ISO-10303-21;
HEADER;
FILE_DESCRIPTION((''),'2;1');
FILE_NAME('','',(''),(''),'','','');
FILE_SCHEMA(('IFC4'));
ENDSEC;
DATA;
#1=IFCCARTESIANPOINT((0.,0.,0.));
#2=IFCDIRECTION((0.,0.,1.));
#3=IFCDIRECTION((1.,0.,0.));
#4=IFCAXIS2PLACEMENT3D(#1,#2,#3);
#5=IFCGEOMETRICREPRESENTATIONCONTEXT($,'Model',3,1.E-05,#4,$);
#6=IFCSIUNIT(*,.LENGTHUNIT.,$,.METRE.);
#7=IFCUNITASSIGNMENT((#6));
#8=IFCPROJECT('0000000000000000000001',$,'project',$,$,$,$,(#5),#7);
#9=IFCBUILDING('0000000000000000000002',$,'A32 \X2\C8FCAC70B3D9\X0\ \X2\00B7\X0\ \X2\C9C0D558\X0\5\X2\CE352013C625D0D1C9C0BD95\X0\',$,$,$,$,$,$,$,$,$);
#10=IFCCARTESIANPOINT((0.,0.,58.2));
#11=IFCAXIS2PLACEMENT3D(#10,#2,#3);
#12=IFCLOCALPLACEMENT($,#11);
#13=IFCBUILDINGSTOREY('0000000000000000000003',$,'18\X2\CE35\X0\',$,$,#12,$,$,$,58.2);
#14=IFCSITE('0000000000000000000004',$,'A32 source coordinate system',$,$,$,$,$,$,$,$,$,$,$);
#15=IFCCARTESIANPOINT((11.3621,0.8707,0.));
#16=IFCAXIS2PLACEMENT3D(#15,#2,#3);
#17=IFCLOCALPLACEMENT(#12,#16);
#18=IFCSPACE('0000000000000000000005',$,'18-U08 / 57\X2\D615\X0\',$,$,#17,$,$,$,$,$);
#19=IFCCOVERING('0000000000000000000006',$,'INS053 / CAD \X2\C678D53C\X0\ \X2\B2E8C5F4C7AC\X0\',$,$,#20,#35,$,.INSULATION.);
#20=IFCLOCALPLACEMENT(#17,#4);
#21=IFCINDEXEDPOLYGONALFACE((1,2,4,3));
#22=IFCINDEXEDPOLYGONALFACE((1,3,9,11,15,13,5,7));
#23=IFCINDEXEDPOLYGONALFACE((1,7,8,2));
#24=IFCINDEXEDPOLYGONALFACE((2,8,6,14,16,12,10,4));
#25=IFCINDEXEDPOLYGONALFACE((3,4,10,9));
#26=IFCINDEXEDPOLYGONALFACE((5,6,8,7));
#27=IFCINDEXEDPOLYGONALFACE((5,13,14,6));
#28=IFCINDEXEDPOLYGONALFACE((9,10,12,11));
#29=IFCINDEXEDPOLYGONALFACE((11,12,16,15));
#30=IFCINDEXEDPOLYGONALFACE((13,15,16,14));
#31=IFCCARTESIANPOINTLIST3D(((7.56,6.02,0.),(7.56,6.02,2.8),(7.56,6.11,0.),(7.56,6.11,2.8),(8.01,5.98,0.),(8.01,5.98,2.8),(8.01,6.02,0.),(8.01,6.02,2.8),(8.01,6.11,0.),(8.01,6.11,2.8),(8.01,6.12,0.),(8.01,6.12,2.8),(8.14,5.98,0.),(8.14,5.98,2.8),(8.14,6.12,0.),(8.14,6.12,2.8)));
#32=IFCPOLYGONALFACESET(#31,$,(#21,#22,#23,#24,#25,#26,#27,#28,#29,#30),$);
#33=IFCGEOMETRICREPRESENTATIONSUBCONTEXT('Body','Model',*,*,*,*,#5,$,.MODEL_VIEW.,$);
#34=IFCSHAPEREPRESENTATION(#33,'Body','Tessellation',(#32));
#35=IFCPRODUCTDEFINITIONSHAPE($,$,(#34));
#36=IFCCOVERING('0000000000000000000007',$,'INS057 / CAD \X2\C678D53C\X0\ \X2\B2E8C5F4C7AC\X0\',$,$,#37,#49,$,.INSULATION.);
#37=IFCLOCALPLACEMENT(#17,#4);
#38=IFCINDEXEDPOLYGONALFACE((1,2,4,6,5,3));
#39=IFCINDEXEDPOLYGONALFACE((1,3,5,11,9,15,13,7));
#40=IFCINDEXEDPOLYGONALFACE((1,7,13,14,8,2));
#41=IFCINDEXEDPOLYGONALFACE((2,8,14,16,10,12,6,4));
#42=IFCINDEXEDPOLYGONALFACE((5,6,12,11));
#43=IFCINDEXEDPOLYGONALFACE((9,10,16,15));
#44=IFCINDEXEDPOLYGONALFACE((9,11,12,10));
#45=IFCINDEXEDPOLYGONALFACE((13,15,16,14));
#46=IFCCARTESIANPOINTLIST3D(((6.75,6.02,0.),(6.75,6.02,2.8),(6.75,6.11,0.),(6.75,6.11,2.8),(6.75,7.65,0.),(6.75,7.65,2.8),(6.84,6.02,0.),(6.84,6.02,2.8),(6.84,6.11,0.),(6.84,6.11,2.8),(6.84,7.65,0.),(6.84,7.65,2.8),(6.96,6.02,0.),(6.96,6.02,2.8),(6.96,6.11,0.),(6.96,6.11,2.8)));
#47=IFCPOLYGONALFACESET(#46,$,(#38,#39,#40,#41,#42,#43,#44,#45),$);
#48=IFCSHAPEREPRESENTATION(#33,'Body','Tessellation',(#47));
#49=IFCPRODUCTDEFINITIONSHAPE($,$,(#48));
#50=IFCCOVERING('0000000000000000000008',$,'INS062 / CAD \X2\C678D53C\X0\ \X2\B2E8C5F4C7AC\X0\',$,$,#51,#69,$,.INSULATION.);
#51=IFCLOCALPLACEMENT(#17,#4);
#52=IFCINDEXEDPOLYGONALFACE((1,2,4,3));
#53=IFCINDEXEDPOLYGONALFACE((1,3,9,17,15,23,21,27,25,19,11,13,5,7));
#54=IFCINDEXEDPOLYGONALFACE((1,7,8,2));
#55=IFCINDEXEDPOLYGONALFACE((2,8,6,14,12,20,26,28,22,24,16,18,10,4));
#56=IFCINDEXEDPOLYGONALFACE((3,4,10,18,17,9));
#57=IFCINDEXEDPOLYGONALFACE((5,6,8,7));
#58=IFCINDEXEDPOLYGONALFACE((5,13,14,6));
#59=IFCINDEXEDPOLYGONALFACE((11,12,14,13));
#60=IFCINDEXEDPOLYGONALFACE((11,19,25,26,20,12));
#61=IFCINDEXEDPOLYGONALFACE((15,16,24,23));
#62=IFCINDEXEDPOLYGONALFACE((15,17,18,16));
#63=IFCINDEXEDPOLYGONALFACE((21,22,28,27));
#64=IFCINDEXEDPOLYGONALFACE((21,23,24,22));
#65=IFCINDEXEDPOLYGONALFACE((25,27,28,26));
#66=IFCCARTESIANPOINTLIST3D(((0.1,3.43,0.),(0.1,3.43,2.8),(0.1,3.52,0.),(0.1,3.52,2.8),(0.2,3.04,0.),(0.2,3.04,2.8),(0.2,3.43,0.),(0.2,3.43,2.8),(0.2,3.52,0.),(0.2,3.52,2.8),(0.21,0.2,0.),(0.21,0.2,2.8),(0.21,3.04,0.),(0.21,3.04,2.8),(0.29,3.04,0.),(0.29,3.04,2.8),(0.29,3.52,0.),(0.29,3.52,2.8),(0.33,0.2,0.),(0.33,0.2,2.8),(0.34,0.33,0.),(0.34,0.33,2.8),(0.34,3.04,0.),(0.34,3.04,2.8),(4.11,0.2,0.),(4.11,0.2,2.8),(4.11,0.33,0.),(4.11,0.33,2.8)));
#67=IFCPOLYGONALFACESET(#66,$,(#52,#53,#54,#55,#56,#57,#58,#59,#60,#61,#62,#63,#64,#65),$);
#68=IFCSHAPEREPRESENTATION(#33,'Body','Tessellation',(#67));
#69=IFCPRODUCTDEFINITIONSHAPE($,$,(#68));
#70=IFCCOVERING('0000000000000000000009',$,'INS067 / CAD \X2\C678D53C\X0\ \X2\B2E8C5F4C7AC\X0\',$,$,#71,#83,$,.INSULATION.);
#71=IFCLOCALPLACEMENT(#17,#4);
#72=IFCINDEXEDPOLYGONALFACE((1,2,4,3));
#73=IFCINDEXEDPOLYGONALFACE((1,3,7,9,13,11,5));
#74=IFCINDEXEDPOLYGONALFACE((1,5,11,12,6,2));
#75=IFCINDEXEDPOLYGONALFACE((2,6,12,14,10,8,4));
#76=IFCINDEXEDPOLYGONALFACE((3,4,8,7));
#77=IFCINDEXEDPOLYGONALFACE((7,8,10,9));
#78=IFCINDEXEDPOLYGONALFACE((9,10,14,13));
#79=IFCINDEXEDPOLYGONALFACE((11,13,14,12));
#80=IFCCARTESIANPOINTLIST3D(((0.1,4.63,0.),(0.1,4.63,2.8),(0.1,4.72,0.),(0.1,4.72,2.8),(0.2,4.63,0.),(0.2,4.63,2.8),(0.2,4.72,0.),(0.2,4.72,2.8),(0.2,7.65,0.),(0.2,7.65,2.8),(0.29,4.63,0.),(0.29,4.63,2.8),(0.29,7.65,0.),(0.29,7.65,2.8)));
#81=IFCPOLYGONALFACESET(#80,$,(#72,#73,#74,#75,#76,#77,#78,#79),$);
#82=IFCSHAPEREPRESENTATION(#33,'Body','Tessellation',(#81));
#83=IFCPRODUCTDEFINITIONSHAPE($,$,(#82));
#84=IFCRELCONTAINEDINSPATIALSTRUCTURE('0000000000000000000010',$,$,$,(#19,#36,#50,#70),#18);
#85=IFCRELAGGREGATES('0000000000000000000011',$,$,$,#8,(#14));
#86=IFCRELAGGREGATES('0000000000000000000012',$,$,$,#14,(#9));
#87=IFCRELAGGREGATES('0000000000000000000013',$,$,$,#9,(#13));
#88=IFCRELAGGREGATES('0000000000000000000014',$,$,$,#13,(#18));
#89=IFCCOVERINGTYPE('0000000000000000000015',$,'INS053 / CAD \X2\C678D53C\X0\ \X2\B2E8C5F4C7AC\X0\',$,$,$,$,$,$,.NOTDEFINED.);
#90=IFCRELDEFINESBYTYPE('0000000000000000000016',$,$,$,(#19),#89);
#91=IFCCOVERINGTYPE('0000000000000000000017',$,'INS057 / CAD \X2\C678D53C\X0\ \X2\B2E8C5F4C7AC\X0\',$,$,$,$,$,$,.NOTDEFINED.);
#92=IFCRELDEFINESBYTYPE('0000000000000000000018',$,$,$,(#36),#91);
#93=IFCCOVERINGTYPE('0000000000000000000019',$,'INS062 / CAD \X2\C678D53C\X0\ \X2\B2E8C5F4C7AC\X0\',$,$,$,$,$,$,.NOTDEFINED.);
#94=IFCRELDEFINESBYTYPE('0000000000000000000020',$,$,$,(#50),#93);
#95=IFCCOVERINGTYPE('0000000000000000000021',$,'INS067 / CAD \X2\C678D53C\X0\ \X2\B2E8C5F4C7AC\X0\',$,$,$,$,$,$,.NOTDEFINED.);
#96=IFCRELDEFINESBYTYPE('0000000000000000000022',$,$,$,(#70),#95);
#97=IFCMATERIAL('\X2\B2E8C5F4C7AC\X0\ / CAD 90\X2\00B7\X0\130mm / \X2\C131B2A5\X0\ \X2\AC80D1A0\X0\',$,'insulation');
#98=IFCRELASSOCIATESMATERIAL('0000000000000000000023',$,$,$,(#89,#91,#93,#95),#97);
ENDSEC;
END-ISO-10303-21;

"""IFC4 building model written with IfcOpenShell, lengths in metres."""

from ifc_helpers import new_model, si_unit, frame, origin, origin_with_axes, place, context, subcontext, project, spatial, polyline, outline, extrude, source, transform, mapped, material, type_object, type_shapes, element, save


model = new_model("IFC4")

# Units and contexts
model_context = context("Model", 3, precision=1e-05, world=origin_with_axes())
body_context = subcontext(model_context, "Body", "Model", "MODEL_VIEW")
ifc_project = project(units=[si_unit("LENGTHUNIT", "METRE")], contexts=[model_context])

# Site, building, storey, space
site = spatial("IfcSite", under=ifc_project, Name="A32 source coordinate system")
building = spatial("IfcBuilding", under=site, Name="A32 주거동 · 지하5층–옥탑지붕")
storey_placement = place(None, frame((0.0, 0.0, 58.2), z_axis=(0.0, 0.0, 1.0), x_axis=(1.0, 0.0, 0.0)))
storey = spatial("IfcBuildingStorey", under=building, at=storey_placement, Name="18층", Elevation=58.2)
space_1_placement = place(storey_placement, frame((11.3621, 0.8707, 0.0), z_axis=(0.0, 0.0, 1.0), x_axis=(1.0, 0.0, 0.0)))
space_1 = spatial("IfcSpace", under=storey, at=space_1_placement, Name="18-U08 / 57형")

# Coverings
ifc_material = material(Name="단열재 / CAD 90·130mm / 성능 검토", Category="insulation")
covering_type_1 = type_object("IfcCoveringType", Name="INS053 / CAD 외피 단열재", PredefinedType="NOTDEFINED", material=ifc_material)
shared_shape_1 = source(origin(), body_context, "Body", "SweptSolid", [
    extrude(outline(polyline([(8.01, 6.12), (8.14, 6.12), (8.14, 5.98), (8.01, 5.98), (8.01, 6.02), (7.56, 6.02), (7.56, 6.11), (8.01, 6.11), (8.01, 6.12)])), origin(), (0.0, 0.0, 1.0), 2.8),
])
type_shapes(covering_type_1, [shared_shape_1])
covering_1_placement = place(space_1_placement, origin_with_axes())
element("IfcCovering", 1, at=covering_1_placement, inside=space_1, type_object=covering_type_1, Name="INS053 / CAD 외피 단열재", PredefinedType="INSULATION", context=body_context, shape_type="MappedRepresentation", body=[
    mapped(shared_shape_1, transform((0.0, 0.0, 0.0), scale=1.0)),
])
covering_type_2 = type_object("IfcCoveringType", Name="INS057 / CAD 외피 단열재", PredefinedType="NOTDEFINED", material=ifc_material)
shared_shape_2 = source(origin(), body_context, "Body", "SweptSolid", [
    extrude(outline(polyline([(6.84, 6.11), (6.96, 6.11), (6.96, 6.02), (6.84, 6.02), (6.75, 6.02), (6.75, 6.11), (6.75, 7.65), (6.84, 7.65), (6.84, 6.11)])), origin(), (0.0, 0.0, 1.0), 2.8),
])
type_shapes(covering_type_2, [shared_shape_2])
covering_2_placement = place(space_1_placement, origin_with_axes())
element("IfcCovering", 2, at=covering_2_placement, inside=space_1, type_object=covering_type_2, Name="INS057 / CAD 외피 단열재", PredefinedType="INSULATION", context=body_context, shape_type="MappedRepresentation", body=[
    mapped(shared_shape_2, transform((0.0, 0.0, 0.0), scale=1.0)),
])
covering_type_3 = type_object("IfcCoveringType", Name="INS062 / CAD 외피 단열재", PredefinedType="NOTDEFINED", material=ifc_material)
shared_shape_3 = source(origin(), body_context, "Body", "SweptSolid", [
    extrude(outline(polyline([(4.11, 0.2), (0.33, 0.2), (0.21, 0.2), (0.21, 3.04), (0.2, 3.04), (0.2, 3.43), (0.1, 3.43), (0.1, 3.52), (0.2, 3.52), (0.29, 3.52), (0.29, 3.04), (0.34, 3.04), (0.34, 0.33), (4.11, 0.33), (4.11, 0.2)])), origin(), (0.0, 0.0, 1.0), 2.8),
])
type_shapes(covering_type_3, [shared_shape_3])
covering_3_placement = place(space_1_placement, origin_with_axes())
element("IfcCovering", 3, at=covering_3_placement, inside=space_1, type_object=covering_type_3, Name="INS062 / CAD 외피 단열재", PredefinedType="INSULATION", context=body_context, shape_type="MappedRepresentation", body=[
    mapped(shared_shape_3, transform((0.0, 0.0, 0.0), scale=1.0)),
])
covering_type_4 = type_object("IfcCoveringType", Name="INS067 / CAD 외피 단열재", PredefinedType="NOTDEFINED", material=ifc_material)
shared_shape_4 = source(origin(), body_context, "Body", "SweptSolid", [
    extrude(outline(polyline([(0.1, 4.72), (0.2, 4.72), (0.2, 7.65), (0.29, 7.65), (0.29, 4.63), (0.2, 4.63), (0.1, 4.63), (0.1, 4.72)])), origin(), (0.0, 0.0, 1.0), 2.8),
])
type_shapes(covering_type_4, [shared_shape_4])
covering_4_placement = place(space_1_placement, origin_with_axes())
element("IfcCovering", 4, at=covering_4_placement, inside=space_1, type_object=covering_type_4, Name="INS067 / CAD 외피 단열재", PredefinedType="INSULATION", context=body_context, shape_type="MappedRepresentation", body=[
    mapped(shared_shape_4, transform((0.0, 0.0, 0.0), scale=1.0)),
])

save(model, "model.ifc")
